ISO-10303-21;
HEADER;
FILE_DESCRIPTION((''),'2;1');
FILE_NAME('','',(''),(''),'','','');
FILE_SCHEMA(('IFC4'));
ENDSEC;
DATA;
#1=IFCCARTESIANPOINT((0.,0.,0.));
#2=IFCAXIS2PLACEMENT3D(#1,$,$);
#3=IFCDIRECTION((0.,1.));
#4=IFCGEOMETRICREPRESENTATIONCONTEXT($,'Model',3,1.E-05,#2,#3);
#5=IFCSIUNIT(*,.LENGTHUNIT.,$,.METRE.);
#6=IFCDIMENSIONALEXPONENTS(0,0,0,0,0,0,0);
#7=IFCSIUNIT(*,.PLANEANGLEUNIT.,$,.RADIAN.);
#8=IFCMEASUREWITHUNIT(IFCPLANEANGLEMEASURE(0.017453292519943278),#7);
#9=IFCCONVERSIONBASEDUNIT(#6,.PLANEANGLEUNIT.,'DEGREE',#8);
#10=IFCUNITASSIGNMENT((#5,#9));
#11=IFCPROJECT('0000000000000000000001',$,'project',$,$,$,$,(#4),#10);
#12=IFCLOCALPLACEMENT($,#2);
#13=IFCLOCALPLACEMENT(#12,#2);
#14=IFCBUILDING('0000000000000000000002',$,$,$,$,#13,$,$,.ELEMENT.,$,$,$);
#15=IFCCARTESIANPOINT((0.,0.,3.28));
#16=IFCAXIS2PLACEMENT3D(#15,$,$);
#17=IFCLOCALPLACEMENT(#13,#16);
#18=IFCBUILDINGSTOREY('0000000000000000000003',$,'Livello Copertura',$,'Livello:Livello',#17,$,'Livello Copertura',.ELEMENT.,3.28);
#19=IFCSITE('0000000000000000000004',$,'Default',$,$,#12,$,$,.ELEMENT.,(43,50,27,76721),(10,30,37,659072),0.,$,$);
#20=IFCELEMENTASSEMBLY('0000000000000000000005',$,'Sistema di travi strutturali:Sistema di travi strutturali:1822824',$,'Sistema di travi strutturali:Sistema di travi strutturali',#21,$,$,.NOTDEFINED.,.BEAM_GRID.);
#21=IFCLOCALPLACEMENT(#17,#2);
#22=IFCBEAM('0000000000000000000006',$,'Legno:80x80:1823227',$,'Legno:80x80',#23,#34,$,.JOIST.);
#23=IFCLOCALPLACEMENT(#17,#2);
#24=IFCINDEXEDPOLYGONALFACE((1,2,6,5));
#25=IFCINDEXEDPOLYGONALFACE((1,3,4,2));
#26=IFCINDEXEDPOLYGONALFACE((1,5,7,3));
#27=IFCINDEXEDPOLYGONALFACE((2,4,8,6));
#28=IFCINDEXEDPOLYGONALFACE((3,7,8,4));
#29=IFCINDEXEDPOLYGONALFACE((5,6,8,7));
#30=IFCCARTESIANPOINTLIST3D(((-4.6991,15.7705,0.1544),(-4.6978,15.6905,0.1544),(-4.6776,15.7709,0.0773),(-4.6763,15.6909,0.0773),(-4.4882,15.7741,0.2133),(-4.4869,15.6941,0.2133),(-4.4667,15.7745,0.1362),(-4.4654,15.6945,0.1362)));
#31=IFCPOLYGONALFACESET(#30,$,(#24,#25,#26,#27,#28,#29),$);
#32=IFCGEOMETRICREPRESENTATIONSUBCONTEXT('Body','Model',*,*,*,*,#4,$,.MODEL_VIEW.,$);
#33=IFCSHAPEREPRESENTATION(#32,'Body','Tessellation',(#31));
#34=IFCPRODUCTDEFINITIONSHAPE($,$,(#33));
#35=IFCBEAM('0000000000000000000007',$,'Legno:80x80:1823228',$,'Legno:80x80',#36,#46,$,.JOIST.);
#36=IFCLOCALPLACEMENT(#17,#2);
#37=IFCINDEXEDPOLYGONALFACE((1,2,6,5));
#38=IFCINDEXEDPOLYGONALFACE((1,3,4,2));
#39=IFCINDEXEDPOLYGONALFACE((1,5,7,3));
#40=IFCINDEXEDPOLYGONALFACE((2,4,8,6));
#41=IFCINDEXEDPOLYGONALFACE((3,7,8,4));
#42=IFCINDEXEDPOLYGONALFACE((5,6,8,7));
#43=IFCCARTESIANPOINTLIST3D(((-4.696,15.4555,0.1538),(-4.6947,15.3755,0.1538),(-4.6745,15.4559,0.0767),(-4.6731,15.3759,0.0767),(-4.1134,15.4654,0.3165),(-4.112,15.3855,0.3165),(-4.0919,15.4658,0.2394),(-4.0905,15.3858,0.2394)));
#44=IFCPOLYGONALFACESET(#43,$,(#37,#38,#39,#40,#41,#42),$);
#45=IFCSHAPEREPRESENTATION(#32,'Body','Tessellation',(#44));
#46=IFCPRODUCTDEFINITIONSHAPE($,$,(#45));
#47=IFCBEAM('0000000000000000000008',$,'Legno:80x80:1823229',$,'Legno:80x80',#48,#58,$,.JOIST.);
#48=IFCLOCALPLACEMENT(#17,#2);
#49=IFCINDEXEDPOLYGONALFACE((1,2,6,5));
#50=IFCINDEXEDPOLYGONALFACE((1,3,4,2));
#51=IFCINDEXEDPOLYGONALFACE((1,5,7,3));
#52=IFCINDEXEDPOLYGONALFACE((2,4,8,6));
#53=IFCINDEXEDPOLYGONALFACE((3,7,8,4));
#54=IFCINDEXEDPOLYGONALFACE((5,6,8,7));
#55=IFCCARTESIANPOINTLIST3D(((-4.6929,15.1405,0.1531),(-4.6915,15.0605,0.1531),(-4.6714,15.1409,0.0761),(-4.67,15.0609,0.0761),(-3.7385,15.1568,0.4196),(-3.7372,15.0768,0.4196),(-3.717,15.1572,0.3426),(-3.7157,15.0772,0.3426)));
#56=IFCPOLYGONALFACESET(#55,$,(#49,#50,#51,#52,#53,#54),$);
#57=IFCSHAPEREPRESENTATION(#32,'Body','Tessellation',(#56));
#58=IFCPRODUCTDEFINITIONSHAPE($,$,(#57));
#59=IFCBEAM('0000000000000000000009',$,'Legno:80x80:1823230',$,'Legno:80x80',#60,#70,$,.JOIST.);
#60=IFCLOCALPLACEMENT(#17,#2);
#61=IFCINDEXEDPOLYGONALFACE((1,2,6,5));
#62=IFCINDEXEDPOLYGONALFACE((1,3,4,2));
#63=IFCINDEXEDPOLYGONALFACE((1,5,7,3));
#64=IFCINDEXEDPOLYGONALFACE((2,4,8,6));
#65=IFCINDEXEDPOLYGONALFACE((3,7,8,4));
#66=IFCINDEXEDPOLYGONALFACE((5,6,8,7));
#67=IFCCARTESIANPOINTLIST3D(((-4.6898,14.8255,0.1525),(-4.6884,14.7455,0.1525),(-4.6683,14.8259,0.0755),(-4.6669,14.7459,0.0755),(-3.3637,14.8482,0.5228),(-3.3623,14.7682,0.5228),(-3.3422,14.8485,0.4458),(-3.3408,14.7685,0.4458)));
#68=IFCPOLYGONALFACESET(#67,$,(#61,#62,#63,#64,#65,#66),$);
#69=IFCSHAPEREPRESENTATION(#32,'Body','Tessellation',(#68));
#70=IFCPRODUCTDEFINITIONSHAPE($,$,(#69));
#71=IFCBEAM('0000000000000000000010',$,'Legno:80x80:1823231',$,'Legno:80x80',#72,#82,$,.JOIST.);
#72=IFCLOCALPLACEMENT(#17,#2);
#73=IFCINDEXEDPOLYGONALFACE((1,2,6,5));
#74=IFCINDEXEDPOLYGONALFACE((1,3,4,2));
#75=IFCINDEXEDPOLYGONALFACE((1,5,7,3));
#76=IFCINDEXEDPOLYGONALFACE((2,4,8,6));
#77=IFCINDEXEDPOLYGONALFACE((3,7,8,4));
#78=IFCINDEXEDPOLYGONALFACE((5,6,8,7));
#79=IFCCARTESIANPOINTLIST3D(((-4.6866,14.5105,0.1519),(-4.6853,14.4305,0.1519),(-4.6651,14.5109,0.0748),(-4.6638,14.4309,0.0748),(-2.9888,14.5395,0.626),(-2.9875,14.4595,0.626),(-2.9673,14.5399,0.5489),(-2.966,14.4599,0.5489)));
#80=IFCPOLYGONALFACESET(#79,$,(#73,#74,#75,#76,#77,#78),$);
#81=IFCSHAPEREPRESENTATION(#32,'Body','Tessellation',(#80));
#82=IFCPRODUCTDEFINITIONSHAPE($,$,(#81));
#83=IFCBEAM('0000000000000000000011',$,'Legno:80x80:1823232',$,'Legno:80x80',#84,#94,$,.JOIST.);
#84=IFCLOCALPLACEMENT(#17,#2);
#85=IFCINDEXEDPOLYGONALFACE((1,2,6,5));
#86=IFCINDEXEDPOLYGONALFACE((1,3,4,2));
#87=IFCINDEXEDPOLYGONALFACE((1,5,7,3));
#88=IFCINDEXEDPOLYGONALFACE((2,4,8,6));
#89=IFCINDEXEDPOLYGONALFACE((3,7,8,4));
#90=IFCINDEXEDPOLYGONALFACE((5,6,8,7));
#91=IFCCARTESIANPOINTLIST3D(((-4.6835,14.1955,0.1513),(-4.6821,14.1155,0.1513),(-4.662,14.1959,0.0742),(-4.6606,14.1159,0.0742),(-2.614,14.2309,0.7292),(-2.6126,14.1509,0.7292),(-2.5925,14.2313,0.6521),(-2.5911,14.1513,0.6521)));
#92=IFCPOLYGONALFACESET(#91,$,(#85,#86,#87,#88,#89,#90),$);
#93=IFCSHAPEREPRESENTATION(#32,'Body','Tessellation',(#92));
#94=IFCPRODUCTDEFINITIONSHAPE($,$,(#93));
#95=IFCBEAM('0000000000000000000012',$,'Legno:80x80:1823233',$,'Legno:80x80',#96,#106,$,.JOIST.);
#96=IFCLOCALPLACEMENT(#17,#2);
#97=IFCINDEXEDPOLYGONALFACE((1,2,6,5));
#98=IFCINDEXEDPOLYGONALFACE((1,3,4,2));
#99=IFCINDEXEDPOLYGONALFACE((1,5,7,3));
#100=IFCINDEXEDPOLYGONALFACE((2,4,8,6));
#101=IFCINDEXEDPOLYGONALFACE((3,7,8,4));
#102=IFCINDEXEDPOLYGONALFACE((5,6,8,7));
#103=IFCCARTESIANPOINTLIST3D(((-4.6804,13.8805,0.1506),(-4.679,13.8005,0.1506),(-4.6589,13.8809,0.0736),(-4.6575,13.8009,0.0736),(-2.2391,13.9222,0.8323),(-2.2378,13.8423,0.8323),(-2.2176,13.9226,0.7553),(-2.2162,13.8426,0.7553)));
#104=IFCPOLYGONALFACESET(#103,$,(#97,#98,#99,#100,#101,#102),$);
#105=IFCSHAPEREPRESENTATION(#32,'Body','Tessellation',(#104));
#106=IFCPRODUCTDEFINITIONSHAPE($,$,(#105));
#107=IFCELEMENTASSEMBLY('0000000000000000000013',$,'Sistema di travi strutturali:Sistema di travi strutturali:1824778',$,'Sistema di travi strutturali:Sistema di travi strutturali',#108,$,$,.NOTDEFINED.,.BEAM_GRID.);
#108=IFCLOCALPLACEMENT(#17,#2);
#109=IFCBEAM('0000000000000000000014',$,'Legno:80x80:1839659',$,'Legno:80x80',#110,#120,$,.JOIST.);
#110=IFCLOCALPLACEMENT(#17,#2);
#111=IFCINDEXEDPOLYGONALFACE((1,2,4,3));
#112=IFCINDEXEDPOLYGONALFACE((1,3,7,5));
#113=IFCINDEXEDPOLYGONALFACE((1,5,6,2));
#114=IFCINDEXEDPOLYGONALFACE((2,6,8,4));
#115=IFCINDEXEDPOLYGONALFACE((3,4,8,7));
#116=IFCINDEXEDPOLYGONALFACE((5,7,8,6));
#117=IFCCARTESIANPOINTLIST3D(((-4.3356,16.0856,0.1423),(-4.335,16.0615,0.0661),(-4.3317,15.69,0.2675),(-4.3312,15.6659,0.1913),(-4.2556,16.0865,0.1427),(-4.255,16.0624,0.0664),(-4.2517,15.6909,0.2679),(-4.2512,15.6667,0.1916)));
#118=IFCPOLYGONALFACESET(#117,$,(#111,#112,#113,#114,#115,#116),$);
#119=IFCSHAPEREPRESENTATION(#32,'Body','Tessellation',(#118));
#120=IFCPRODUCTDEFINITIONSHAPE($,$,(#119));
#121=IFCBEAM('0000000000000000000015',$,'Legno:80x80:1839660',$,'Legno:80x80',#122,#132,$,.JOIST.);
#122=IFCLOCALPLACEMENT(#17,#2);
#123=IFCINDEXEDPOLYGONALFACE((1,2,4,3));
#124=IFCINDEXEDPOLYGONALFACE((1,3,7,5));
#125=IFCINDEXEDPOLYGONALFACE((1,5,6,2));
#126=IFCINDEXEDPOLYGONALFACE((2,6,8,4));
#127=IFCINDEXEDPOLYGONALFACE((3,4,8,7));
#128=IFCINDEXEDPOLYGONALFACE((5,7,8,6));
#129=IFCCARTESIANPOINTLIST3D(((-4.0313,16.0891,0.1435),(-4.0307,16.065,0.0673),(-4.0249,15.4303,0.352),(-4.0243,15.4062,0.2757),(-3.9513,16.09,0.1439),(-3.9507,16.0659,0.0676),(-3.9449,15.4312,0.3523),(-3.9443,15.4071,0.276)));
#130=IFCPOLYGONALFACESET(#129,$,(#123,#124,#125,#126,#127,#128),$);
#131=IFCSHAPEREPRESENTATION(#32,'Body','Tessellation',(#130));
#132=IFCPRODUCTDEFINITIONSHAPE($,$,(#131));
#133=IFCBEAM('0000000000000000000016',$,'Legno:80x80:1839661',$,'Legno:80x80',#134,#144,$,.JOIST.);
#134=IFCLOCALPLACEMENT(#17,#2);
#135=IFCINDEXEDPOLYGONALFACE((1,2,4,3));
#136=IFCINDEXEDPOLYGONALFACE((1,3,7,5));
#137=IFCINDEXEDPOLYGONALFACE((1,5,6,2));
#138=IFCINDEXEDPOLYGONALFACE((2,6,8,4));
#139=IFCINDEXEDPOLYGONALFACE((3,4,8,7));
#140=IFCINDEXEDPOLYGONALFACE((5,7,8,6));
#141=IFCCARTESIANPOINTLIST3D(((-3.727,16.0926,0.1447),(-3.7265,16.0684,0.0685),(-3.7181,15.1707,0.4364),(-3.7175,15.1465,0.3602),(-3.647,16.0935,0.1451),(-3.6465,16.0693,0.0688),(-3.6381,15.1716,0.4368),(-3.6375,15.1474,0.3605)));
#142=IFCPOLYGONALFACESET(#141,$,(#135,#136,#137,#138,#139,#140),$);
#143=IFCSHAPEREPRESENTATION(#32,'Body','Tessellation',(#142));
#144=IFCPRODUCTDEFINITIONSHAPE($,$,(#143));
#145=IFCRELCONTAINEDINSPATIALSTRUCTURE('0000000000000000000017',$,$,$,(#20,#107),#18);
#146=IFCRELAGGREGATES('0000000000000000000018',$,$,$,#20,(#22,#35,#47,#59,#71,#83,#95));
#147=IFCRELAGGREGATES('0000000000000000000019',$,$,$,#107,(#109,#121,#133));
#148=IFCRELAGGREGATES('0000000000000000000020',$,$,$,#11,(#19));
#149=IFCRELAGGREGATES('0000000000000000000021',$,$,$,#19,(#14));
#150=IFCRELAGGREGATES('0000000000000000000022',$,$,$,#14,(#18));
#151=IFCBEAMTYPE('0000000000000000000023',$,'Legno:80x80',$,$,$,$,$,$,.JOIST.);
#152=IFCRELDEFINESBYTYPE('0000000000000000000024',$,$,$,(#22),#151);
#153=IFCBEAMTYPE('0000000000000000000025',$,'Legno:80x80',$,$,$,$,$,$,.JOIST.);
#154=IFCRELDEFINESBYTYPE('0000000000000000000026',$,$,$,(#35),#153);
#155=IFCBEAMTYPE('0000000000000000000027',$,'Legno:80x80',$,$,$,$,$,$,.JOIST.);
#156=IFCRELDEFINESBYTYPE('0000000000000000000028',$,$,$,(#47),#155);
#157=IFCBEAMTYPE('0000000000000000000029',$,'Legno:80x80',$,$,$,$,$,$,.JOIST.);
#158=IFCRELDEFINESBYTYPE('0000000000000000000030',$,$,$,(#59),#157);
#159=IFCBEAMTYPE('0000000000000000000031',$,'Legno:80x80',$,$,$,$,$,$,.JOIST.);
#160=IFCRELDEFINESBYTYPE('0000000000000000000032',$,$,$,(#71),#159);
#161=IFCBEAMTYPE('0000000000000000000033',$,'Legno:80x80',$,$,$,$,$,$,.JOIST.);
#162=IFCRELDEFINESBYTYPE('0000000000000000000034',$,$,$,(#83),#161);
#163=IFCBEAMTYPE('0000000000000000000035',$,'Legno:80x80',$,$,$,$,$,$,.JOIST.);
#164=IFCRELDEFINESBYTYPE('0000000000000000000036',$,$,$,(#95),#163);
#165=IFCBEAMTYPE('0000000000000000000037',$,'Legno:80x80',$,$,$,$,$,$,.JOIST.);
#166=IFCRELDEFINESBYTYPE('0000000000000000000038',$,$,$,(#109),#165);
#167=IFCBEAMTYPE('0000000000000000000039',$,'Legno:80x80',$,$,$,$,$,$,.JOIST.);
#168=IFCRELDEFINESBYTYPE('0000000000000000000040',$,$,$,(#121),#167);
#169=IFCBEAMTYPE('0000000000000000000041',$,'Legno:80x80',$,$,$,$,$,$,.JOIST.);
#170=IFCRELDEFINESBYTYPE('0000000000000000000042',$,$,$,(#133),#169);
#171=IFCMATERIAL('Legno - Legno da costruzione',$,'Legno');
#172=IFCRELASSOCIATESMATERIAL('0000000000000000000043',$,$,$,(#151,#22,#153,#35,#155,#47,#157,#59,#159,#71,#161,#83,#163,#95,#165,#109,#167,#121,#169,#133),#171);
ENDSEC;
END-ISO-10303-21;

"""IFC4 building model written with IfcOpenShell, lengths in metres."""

from ifc_helpers import new_model, entity, si_unit, converted_unit, direction, frame, origin, place, context, subcontext, project, spatial, indexed_curve, outline, extrude, source, transform, mapped, material, type_object, type_shapes, element, aggregate, save


model = new_model("IFC4")

# Units and contexts
model_context = context("Model", 3, precision=1e-05, world=origin(), true_north=direction((0.0, 1.0)))
body_context = subcontext(model_context, "Body", "Model", "MODEL_VIEW")
ifc_project = project(units=[si_unit("LENGTHUNIT", "METRE"), converted_unit("PLANEANGLEUNIT", "DEGREE", entity("IfcPlaneAngleMeasure", 0.017453292519943278), si_unit("PLANEANGLEUNIT", "RADIAN"), dimensions=[0, 0, 0, 0, 0, 0, 0])], contexts=[model_context])

# Site, building, storey
site_placement = place(None, origin())
site = spatial("IfcSite", under=ifc_project, at=site_placement, Name="Default", CompositionType="ELEMENT", RefLatitude=(43, 50, 27, 76721), RefLongitude=(10, 30, 37, 659072), RefElevation=0.0)
building_placement = place(site_placement, origin())
building = spatial("IfcBuilding", under=site, at=building_placement, CompositionType="ELEMENT")
storey_placement = place(building_placement, frame((0.0, 0.0, 3.28)))
storey = spatial("IfcBuildingStorey", under=building, at=storey_placement, Name="Livello Copertura", ObjectType="Livello:Livello", LongName="Livello Copertura", CompositionType="ELEMENT", Elevation=3.28)

# Element assemblies, beams
assembly_1_placement = place(storey_placement, origin())
assembly_1 = element("IfcElementAssembly", 1, at=assembly_1_placement, inside=storey, Name="Sistema di travi strutturali:Sistema di travi strutturali:1822824", ObjectType="Sistema di travi strutturali:Sistema di travi strutturali", AssemblyPlace="NOTDEFINED", PredefinedType="BEAM_GRID")
ifc_material = material(Name="Legno - Legno da costruzione", Category="Legno")
beam_type_1 = type_object("IfcBeamType", Name="Legno:80x80", PredefinedType="JOIST", material=ifc_material)
shared_shape_1 = source(origin(), body_context, "Body", "SweptSolid", [
    extrude(outline(indexed_curve([(-0.1095, -0.04), (0.1095, -0.04), (0.1095, 0.04), (-0.1095, 0.04), (-0.1095, -0.04)], self_intersect=False)), frame((0.0, 0.0, -0.04), z_axis=(0.0, 0.0, 1.0), x_axis=(-1.0, 0.0, 0.0)), (0.0, 0.0, 1.0), 0.08),
])
type_shapes(beam_type_1, [shared_shape_1])
beam_1_placement = place(assembly_1_placement, frame((-4.5823, 15.7325, 0.1453), z_axis=(-0.268881, -0.004594, 0.963163), x_axis=(0.963022, 0.016456, 0.26892)))
beam_1 = element("IfcBeam", 2, at=beam_1_placement, type_object=beam_type_1, material=ifc_material, Name="Legno:80x80:1823227", ObjectType="Legno:80x80", PredefinedType="JOIST", context=body_context, shape_type="MappedRepresentation", body=[
    mapped(shared_shape_1, transform((0.0, 0.0, 0.0), scale=1.0)),
])
beam_type_2 = type_object("IfcBeamType", Name="Legno:80x80", PredefinedType="JOIST", material=ifc_material)
shared_shape_2 = source(origin(), body_context, "Body", "SweptSolid", [
    extrude(outline(indexed_curve([(-0.3025, -0.04), (0.3025, -0.04), (0.3025, 0.04), (-0.3025, 0.04), (-0.3025, -0.04)], self_intersect=False)), frame((0.0, 0.0, -0.04), z_axis=(0.0, 0.0, 1.0), x_axis=(-1.0, 0.0, 0.0)), (0.0, 0.0, 1.0), 0.08),
])
type_shapes(beam_type_2, [shared_shape_2])
beam_2_placement = place(assembly_1_placement, frame((-4.3933, 15.4207, 0.1966), z_axis=(-0.268881, -0.004594, 0.963163), x_axis=(0.963022, 0.016456, 0.26892)))
beam_2 = element("IfcBeam", 3, at=beam_2_placement, type_object=beam_type_2, material=ifc_material, Name="Legno:80x80:1823228", ObjectType="Legno:80x80", PredefinedType="JOIST", context=body_context, shape_type="MappedRepresentation", body=[
    mapped(shared_shape_2, transform((0.0, 0.0, 0.0), scale=1.0)),
])
beam_type_3 = type_object("IfcBeamType", Name="Legno:80x80", PredefinedType="JOIST", material=ifc_material)
shared_shape_3 = source(origin(), body_context, "Body", "SweptSolid", [
    extrude(outline(indexed_curve([(-0.4955, -0.04), (0.4955, -0.04), (0.4955, 0.04), (-0.4955, 0.04), (-0.4955, -0.04)], self_intersect=False)), frame((0.0, 0.0, -0.04), z_axis=(0.0, 0.0, 1.0), x_axis=(-1.0, 0.0, 0.0)), (0.0, 0.0, 1.0), 0.08),
])
type_shapes(beam_type_3, [shared_shape_3])
beam_3_placement = place(assembly_1_placement, frame((-4.2043, 15.1088, 0.2479), z_axis=(-0.268881, -0.004594, 0.963163), x_axis=(0.963022, 0.016456, 0.26892)))
beam_3 = element("IfcBeam", 4, at=beam_3_placement, type_object=beam_type_3, material=ifc_material, Name="Legno:80x80:1823229", ObjectType="Legno:80x80", PredefinedType="JOIST", context=body_context, shape_type="MappedRepresentation", body=[
    mapped(shared_shape_3, transform((0.0, 0.0, 0.0), scale=1.0)),
])
beam_type_4 = type_object("IfcBeamType", Name="Legno:80x80", PredefinedType="JOIST", material=ifc_material)
shared_shape_4 = source(origin(), body_context, "Body", "SweptSolid", [
    extrude(outline(indexed_curve([(-0.6885, -0.04), (0.6885, -0.04), (0.6885, 0.04), (-0.6885, 0.04), (-0.6885, -0.04)], self_intersect=False)), frame((0.0, 0.0, -0.04), z_axis=(0.0, 0.0, 1.0), x_axis=(-1.0, 0.0, 0.0)), (0.0, 0.0, 1.0), 0.08),
])
type_shapes(beam_type_4, [shared_shape_4])
beam_4_placement = place(assembly_1_placement, frame((-4.0153, 14.797, 0.2991), z_axis=(-0.268881, -0.004594, 0.963163), x_axis=(0.963022, 0.016456, 0.26892)))
beam_4 = element("IfcBeam", 5, at=beam_4_placement, type_object=beam_type_4, material=ifc_material, Name="Legno:80x80:1823230", ObjectType="Legno:80x80", PredefinedType="JOIST", context=body_context, shape_type="MappedRepresentation", body=[
    mapped(shared_shape_4, transform((0.0, 0.0, 0.0), scale=1.0)),
])
beam_type_5 = type_object("IfcBeamType", Name="Legno:80x80", PredefinedType="JOIST", material=ifc_material)
shared_shape_5 = source(origin(), body_context, "Body", "SweptSolid", [
    extrude(outline(indexed_curve([(-0.8815, -0.04), (0.8815, -0.04), (0.8815, 0.04), (-0.8815, 0.04), (-0.8815, -0.04)], self_intersect=False)), frame((0.0, 0.0, -0.04), z_axis=(0.0, 0.0, 1.0), x_axis=(-1.0, 0.0, 0.0)), (0.0, 0.0, 1.0), 0.08),
])
type_shapes(beam_type_5, [shared_shape_5])
beam_5_placement = place(assembly_1_placement, frame((-3.8263, 14.4852, 0.3504), z_axis=(-0.268881, -0.004594, 0.963163), x_axis=(0.963022, 0.016456, 0.26892)))
beam_5 = element("IfcBeam", 6, at=beam_5_placement, type_object=beam_type_5, material=ifc_material, Name="Legno:80x80:1823231", ObjectType="Legno:80x80", PredefinedType="JOIST", context=body_context, shape_type="MappedRepresentation", body=[
    mapped(shared_shape_5, transform((0.0, 0.0, 0.0), scale=1.0)),
])
beam_type_6 = type_object("IfcBeamType", Name="Legno:80x80", PredefinedType="JOIST", material=ifc_material)
shared_shape_6 = source(origin(), body_context, "Body", "SweptSolid", [
    extrude(outline(indexed_curve([(-1.0745, -0.04), (1.0745, -0.04), (1.0745, 0.04), (-1.0745, 0.04), (-1.0745, -0.04)], self_intersect=False)), frame((0.0, 0.0, -0.04), z_axis=(0.0, 0.0, 1.0), x_axis=(-1.0, 0.0, 0.0)), (0.0, 0.0, 1.0), 0.08),
])
type_shapes(beam_type_6, [shared_shape_6])
beam_6_placement = place(assembly_1_placement, frame((-3.6373, 14.1734, 0.4017), z_axis=(-0.268881, -0.004594, 0.963163), x_axis=(0.963022, 0.016456, 0.26892)))
beam_6 = element("IfcBeam", 7, at=beam_6_placement, type_object=beam_type_6, material=ifc_material, Name="Legno:80x80:1823232", ObjectType="Legno:80x80", PredefinedType="JOIST", context=body_context, shape_type="MappedRepresentation", body=[
    mapped(shared_shape_6, transform((0.0, 0.0, 0.0), scale=1.0)),
])
beam_type_7 = type_object("IfcBeamType", Name="Legno:80x80", PredefinedType="JOIST", material=ifc_material)
shared_shape_7 = source(origin(), body_context, "Body", "SweptSolid", [
    extrude(outline(indexed_curve([(-1.2675, -0.04), (1.2675, -0.04), (1.2675, 0.04), (-1.2675, 0.04), (-1.2675, -0.04)], self_intersect=False)), frame((0.0, 0.0, -0.04), z_axis=(0.0, 0.0, 1.0), x_axis=(-1.0, 0.0, 0.0)), (0.0, 0.0, 1.0), 0.08),
])
type_shapes(beam_type_7, [shared_shape_7])
beam_7_placement = place(assembly_1_placement, frame((-3.4483, 13.8616, 0.453), z_axis=(-0.268881, -0.004594, 0.963163), x_axis=(0.963022, 0.016456, 0.26892)))
beam_7 = element("IfcBeam", 8, at=beam_7_placement, type_object=beam_type_7, material=ifc_material, Name="Legno:80x80:1823233", ObjectType="Legno:80x80", PredefinedType="JOIST", context=body_context, shape_type="MappedRepresentation", body=[
    mapped(shared_shape_7, transform((0.0, 0.0, 0.0), scale=1.0)),
])
aggregate(assembly_1, [beam_1, beam_2, beam_3, beam_4, beam_5, beam_6, beam_7])
assembly_2_placement = place(storey_placement, origin())
assembly_2 = element("IfcElementAssembly", 9, at=assembly_2_placement, inside=storey, Name="Sistema di travi strutturali:Sistema di travi strutturali:1824778", ObjectType="Sistema di travi strutturali:Sistema di travi strutturali", AssemblyPlace="NOTDEFINED", PredefinedType="BEAM_GRID")
beam_type_8 = type_object("IfcBeamType", Name="Legno:80x80", PredefinedType="JOIST", material=ifc_material)
shared_shape_8 = source(origin(), body_context, "Body", "SweptSolid", [
    extrude(outline(indexed_curve([(-0.2075, -0.04), (0.2075, -0.04), (0.2075, 0.04), (-0.2075, 0.04), (-0.2075, -0.04)], self_intersect=False)), frame((0.0, 0.0, -0.04), z_axis=(0.0, 0.0, 1.0), x_axis=(-1.0, 0.0, 0.0)), (0.0, 0.0, 1.0), 0.08),
])
type_shapes(beam_type_8, [shared_shape_8])
beam_8_placement = place(assembly_2_placement, frame((-4.2934, 15.8762, 0.167), z_axis=(-0.007187, 0.301619, 0.953402), x_axis=(0.009277, -0.953365, 0.301677)))
beam_8 = element("IfcBeam", 10, at=beam_8_placement, type_object=beam_type_8, material=ifc_material, Name="Legno:80x80:1839659", ObjectType="Legno:80x80", PredefinedType="JOIST", context=body_context, shape_type="MappedRepresentation", body=[
    mapped(shared_shape_8, transform((0.0, 0.0, 0.0), scale=1.0)),
])
beam_type_9 = type_object("IfcBeamType", Name="Legno:80x80", PredefinedType="JOIST", material=ifc_material)
shared_shape_9 = source(origin(), body_context, "Body", "SweptSolid", [
    extrude(outline(indexed_curve([(-0.3455, -0.04), (0.3455, -0.04), (0.3455, 0.04), (-0.3455, 0.04), (-0.3455, -0.04)], self_intersect=False)), frame((0.0, 0.0, -0.04), z_axis=(0.0, 0.0, 1.0), x_axis=(-1.0, 0.0, 0.0)), (0.0, 0.0, 1.0), 0.08),
])
type_shapes(beam_type_9, [shared_shape_9])
beam_9_placement = place(assembly_2_placement, frame((-3.9878, 15.7481, 0.2098), z_axis=(-0.007187, 0.301619, 0.953402), x_axis=(0.009277, -0.953365, 0.301677)))
beam_9 = element("IfcBeam", 11, at=beam_9_placement, type_object=beam_type_9, material=ifc_material, Name="Legno:80x80:1839660", ObjectType="Legno:80x80", PredefinedType="JOIST", context=body_context, shape_type="MappedRepresentation", body=[
    mapped(shared_shape_9, transform((0.0, 0.0, 0.0), scale=1.0)),
])
beam_type_10 = type_object("IfcBeamType", Name="Legno:80x80", PredefinedType="JOIST", material=ifc_material)
shared_shape_10 = source(origin(), body_context, "Body", "SweptSolid", [
    extrude(outline(indexed_curve([(-0.4835, -0.04), (0.4835, -0.04), (0.4835, 0.04), (-0.4835, 0.04), (-0.4835, -0.04)], self_intersect=False)), frame((0.0, 0.0, -0.04), z_axis=(0.0, 0.0, 1.0), x_axis=(-1.0, 0.0, 0.0)), (0.0, 0.0, 1.0), 0.08),
])
type_shapes(beam_type_10, [shared_shape_10])
beam_10_placement = place(assembly_2_placement, frame((-3.6823, 15.62, 0.2526), z_axis=(-0.007187, 0.301619, 0.953402), x_axis=(0.009277, -0.953365, 0.301677)))
beam_10 = element("IfcBeam", 12, at=beam_10_placement, type_object=beam_type_10, material=ifc_material, Name="Legno:80x80:1839661", ObjectType="Legno:80x80", PredefinedType="JOIST", context=body_context, shape_type="MappedRepresentation", body=[
    mapped(shared_shape_10, transform((0.0, 0.0, 0.0), scale=1.0)),
])
aggregate(assembly_2, [beam_8, beam_9, beam_10])

save(model, "model.ifc")
